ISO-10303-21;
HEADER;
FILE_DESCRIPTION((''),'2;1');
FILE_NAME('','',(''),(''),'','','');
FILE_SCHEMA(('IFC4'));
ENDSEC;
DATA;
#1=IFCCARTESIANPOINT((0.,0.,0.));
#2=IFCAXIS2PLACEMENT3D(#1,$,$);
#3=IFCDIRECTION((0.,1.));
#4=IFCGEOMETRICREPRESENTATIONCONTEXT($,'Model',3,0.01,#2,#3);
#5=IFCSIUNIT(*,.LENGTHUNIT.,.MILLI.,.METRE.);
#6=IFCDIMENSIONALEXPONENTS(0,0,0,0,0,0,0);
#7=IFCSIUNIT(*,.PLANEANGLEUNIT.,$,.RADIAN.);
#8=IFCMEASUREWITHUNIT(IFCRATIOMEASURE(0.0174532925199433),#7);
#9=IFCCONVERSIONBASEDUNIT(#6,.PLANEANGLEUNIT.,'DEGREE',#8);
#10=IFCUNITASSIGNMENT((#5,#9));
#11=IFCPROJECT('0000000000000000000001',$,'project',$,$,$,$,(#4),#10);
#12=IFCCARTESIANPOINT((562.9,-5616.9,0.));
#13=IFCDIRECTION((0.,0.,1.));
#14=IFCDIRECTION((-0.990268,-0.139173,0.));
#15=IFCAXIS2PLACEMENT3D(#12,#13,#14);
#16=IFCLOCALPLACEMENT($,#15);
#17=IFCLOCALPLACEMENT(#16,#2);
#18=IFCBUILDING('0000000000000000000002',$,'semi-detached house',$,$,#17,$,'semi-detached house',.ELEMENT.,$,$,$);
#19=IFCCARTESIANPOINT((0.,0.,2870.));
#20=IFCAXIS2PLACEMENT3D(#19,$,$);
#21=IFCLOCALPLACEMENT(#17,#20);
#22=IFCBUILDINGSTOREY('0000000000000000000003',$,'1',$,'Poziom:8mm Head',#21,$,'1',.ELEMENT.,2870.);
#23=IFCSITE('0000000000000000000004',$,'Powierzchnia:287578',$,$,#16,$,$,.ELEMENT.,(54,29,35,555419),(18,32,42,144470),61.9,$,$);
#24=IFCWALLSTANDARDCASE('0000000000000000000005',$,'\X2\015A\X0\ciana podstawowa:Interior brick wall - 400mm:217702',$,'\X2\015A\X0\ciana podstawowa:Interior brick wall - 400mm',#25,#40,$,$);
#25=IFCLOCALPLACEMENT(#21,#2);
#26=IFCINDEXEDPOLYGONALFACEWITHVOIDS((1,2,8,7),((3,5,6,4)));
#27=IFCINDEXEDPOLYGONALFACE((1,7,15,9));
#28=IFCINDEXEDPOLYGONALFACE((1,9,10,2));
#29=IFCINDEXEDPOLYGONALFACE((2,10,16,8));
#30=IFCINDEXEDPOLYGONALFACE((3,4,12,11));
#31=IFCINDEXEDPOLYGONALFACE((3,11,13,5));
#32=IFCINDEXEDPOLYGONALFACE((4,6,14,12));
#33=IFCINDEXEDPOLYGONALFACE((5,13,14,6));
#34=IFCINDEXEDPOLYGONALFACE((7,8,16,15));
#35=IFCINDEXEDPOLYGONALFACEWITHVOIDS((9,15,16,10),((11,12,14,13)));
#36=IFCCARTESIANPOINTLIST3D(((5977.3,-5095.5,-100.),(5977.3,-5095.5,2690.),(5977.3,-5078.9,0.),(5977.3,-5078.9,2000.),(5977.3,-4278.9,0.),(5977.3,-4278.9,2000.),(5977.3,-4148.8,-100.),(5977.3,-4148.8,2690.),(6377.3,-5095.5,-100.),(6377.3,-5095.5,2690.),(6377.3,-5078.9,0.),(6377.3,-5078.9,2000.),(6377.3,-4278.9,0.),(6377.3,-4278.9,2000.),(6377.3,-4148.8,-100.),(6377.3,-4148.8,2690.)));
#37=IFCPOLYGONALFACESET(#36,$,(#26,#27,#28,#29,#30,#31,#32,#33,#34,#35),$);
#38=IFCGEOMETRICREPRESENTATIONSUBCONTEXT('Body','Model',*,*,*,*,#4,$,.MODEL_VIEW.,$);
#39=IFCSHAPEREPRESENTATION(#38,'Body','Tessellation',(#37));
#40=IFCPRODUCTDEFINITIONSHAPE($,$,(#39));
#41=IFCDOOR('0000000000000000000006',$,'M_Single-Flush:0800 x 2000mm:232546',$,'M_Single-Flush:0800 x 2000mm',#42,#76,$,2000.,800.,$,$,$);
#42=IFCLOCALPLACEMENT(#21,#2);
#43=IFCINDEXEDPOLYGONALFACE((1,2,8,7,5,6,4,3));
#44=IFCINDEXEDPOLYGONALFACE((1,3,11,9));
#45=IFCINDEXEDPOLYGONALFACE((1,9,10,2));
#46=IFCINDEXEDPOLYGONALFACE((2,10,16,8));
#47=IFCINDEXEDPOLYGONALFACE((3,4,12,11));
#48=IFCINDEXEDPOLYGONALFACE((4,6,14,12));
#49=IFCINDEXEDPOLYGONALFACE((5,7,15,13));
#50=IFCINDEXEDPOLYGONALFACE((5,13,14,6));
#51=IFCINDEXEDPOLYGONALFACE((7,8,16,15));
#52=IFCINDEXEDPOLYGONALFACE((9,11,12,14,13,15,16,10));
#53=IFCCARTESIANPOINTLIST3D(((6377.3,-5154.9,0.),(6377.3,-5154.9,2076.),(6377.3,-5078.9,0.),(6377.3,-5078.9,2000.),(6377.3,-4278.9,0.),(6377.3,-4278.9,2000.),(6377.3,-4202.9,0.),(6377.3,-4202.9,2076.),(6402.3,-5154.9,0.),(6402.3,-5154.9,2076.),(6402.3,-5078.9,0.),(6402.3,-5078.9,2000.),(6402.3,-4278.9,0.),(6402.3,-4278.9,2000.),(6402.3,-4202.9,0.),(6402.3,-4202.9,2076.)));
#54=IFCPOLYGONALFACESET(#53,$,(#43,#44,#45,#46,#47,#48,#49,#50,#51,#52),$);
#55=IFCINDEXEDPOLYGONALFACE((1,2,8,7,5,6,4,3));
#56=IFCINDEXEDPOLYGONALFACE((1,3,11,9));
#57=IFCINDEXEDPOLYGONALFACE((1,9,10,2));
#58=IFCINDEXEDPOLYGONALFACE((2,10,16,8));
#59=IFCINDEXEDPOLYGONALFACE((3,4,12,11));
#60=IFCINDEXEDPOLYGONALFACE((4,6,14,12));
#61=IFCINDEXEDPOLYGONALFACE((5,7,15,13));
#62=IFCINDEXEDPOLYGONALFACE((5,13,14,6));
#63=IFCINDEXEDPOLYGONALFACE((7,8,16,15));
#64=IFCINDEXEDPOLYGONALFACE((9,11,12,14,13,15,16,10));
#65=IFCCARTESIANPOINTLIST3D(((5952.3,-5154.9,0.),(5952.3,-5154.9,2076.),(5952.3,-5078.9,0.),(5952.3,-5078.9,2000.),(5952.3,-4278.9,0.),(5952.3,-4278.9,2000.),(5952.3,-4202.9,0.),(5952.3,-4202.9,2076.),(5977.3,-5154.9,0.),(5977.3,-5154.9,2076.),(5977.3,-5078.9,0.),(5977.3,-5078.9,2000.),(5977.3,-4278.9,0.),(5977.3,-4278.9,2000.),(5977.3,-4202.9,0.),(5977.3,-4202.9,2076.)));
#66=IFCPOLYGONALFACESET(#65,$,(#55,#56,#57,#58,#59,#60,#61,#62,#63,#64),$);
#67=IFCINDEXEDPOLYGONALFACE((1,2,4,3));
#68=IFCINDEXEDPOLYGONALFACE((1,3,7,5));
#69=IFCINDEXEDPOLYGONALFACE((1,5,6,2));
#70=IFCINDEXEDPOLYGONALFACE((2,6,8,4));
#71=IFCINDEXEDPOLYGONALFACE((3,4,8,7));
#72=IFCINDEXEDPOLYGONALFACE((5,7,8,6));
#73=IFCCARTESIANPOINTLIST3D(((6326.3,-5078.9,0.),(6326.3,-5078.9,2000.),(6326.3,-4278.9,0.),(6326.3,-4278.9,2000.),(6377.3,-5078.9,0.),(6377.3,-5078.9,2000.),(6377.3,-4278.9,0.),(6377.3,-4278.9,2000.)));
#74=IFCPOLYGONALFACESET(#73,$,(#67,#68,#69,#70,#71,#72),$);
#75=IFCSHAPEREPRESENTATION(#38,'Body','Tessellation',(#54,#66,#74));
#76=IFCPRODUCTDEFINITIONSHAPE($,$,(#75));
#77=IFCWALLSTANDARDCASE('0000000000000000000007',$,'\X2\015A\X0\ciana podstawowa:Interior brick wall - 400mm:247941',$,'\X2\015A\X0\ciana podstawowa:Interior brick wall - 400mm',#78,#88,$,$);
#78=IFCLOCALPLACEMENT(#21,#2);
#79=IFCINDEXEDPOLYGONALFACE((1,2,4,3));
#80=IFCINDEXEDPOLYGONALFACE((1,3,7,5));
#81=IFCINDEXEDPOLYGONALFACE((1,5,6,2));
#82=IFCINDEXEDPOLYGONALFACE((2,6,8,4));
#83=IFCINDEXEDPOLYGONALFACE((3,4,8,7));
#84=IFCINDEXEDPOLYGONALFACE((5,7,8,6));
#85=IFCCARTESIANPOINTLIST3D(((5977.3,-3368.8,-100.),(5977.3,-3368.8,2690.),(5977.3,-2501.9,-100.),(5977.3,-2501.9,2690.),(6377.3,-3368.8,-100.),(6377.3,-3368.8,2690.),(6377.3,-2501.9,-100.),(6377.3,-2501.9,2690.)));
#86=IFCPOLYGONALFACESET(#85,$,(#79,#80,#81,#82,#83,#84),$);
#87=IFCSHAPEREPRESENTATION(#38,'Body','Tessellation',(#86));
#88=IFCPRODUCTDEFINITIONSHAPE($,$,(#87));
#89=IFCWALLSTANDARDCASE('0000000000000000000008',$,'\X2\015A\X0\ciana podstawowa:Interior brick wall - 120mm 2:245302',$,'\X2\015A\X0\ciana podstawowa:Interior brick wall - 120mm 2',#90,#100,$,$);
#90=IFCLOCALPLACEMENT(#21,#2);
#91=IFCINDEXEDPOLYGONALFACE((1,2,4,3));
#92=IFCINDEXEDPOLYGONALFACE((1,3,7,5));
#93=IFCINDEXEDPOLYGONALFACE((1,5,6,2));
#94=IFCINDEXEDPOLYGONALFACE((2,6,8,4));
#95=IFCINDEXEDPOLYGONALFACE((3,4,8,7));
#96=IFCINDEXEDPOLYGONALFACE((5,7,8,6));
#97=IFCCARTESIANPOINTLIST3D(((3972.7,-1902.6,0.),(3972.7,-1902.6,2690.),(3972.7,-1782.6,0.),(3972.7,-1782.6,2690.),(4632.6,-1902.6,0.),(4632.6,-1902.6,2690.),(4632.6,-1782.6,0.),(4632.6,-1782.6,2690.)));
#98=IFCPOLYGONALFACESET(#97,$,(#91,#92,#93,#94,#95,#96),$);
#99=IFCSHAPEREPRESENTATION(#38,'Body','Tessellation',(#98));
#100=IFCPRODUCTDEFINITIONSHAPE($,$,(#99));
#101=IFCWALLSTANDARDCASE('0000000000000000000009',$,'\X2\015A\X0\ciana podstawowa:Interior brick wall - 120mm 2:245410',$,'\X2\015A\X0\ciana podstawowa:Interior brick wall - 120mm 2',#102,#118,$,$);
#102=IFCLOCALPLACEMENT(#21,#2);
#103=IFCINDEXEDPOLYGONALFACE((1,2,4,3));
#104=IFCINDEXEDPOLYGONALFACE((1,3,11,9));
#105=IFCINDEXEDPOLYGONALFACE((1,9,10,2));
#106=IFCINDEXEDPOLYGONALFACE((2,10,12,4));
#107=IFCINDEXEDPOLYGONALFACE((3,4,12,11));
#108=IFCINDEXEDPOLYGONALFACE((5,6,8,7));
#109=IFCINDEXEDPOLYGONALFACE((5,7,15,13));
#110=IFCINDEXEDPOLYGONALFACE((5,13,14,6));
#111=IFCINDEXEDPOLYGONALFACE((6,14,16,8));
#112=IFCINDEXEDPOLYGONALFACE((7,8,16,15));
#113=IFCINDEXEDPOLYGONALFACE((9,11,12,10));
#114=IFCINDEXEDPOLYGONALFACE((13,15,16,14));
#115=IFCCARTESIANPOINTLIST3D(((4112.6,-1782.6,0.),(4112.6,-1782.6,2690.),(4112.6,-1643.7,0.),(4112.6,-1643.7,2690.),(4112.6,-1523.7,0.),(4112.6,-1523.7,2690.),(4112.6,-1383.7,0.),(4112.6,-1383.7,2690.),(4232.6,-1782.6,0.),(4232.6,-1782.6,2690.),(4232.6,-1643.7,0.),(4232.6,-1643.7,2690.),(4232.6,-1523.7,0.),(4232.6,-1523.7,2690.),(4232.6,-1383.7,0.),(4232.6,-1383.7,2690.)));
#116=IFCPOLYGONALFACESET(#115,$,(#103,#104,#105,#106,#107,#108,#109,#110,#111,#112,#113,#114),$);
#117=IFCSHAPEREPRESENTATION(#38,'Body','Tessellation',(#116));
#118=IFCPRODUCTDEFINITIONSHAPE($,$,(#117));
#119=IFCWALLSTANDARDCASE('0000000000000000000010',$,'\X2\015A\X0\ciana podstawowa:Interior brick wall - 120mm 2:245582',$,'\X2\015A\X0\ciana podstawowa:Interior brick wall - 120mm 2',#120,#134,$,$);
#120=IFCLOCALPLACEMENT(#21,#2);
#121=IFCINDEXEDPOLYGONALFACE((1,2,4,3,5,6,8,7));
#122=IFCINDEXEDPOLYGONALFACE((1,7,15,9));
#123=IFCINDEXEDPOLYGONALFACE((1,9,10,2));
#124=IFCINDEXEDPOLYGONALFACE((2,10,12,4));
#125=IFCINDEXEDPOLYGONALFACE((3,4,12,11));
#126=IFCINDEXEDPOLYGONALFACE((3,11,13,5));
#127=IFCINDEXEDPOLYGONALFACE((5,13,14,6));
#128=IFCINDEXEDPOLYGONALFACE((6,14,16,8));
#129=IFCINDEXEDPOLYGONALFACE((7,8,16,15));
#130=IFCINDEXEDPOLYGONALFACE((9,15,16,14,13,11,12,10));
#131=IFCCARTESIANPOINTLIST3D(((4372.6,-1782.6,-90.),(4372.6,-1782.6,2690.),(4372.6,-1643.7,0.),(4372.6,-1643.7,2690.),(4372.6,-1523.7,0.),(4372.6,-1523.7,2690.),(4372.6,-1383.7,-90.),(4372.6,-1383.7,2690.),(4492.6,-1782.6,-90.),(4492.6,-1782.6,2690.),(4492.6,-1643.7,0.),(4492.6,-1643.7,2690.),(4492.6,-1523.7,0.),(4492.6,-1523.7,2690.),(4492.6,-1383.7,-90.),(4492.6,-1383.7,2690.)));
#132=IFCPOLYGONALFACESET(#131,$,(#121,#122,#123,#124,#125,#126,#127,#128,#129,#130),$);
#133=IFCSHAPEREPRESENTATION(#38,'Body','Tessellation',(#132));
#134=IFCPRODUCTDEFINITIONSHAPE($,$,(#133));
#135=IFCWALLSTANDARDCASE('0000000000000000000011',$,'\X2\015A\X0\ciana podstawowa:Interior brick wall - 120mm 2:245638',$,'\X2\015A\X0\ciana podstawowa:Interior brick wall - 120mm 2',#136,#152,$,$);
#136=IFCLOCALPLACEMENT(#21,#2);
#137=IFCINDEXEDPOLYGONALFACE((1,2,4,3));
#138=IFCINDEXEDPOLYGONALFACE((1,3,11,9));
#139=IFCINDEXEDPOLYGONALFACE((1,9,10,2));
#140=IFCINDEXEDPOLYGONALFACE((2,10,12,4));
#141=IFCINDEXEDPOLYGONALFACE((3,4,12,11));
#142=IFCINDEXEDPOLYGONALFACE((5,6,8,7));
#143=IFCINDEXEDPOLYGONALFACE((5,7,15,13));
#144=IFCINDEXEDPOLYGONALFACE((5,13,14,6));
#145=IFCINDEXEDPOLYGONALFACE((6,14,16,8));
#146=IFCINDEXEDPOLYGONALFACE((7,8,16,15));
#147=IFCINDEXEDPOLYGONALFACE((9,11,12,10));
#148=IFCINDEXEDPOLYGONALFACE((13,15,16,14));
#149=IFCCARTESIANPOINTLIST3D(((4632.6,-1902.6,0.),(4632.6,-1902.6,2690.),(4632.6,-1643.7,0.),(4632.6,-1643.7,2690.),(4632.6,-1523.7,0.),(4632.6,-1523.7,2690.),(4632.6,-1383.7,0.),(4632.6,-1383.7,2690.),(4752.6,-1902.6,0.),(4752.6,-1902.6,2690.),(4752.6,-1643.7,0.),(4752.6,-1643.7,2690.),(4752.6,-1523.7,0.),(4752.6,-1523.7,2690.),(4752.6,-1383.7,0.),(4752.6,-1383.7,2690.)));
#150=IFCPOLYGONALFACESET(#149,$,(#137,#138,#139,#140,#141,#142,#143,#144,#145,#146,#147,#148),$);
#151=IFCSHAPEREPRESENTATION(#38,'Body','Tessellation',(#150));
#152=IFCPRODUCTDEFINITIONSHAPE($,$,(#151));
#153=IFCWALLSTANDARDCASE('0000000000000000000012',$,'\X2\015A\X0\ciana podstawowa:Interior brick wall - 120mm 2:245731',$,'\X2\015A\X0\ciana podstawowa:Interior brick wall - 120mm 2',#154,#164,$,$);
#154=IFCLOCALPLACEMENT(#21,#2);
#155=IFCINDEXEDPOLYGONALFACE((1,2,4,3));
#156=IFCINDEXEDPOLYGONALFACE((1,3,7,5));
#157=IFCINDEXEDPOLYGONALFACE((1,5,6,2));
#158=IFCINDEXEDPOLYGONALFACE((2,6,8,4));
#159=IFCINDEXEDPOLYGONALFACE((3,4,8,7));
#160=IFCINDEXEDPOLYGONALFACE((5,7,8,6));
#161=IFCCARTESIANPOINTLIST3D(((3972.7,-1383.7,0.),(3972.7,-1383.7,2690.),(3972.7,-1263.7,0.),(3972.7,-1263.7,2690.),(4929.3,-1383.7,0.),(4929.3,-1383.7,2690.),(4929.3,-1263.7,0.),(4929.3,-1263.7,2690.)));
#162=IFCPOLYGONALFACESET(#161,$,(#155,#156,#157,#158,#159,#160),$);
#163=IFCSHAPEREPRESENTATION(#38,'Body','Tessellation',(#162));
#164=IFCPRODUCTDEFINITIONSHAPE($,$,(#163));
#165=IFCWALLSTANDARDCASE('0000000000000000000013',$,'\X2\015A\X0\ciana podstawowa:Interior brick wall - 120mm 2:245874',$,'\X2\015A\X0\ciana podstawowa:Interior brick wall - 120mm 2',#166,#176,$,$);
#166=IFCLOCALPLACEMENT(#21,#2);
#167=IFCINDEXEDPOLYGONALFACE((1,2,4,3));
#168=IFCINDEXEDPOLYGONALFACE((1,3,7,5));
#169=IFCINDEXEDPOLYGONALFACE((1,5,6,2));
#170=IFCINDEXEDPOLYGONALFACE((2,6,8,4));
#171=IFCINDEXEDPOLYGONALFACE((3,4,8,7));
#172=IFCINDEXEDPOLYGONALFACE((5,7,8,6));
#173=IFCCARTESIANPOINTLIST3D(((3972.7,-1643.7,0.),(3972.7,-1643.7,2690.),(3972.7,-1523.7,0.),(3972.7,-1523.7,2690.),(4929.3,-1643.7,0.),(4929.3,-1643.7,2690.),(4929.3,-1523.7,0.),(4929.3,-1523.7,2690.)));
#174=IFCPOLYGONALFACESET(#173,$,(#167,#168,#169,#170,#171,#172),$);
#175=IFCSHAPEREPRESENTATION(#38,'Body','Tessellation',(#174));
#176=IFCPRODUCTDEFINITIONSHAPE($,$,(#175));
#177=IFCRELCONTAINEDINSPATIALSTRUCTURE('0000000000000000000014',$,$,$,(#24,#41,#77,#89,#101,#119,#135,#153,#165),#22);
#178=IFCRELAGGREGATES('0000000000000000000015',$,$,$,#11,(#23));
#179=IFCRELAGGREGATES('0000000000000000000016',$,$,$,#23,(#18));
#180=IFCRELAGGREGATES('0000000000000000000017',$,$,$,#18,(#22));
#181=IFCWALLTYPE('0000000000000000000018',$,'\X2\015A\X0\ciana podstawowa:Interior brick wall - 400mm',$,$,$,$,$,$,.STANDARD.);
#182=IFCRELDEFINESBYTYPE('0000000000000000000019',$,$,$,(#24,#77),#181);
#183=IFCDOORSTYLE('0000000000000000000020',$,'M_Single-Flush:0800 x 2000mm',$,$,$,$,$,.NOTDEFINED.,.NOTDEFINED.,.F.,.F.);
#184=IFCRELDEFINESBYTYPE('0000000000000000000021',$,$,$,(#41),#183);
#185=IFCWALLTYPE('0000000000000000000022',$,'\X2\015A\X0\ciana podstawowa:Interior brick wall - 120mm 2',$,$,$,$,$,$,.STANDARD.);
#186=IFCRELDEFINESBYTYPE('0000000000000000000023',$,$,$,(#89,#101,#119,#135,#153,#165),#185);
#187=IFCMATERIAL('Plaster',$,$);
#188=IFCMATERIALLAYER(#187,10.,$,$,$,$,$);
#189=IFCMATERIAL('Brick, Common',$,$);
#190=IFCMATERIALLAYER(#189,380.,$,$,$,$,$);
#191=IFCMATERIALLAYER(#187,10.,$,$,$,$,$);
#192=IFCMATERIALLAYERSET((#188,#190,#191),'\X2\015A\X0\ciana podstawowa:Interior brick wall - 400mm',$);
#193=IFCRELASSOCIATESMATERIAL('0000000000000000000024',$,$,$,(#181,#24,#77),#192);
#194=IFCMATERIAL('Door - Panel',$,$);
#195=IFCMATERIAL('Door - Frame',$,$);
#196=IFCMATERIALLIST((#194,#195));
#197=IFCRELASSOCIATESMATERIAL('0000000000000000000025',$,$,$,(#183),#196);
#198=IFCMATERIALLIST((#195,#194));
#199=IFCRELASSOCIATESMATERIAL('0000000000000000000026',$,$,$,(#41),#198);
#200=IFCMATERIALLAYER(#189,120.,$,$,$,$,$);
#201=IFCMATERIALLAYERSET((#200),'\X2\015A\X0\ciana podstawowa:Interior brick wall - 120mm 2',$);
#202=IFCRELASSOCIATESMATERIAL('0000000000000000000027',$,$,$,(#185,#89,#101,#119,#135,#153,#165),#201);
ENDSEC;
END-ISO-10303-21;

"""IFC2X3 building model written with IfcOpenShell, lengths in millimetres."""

from ifc_helpers import new_model, entity, si_unit, converted_unit, direction, frame, frame_2d, origin, place, context, subcontext, project, spatial, polyline, rectangle, outline, extrude, clip, bounded_halfspace, source, transform, mapped, material, material_list, layer, layer_set, layer_usage, type_object, type_shapes, element, fill, save


model = new_model("IFC2X3")

# Units and contexts
model_context = context("Model", 3, precision=0.01, world=origin(), true_north=direction((0.0, 1.0)))
body_context = subcontext(model_context, "Body", "Model", "MODEL_VIEW")
ifc_project = project(units=[si_unit("LENGTHUNIT", "METRE", prefix="MILLI"), converted_unit("PLANEANGLEUNIT", "DEGREE", entity("IfcRatioMeasure", 0.0174532925199433), si_unit("PLANEANGLEUNIT", "RADIAN"), dimensions=[0, 0, 0, 0, 0, 0, 0])], contexts=[model_context])

# Site, building, storey
site_placement = place(None, frame((562.9, -5616.9, 0.0), z_axis=(0.0, 0.0, 1.0), x_axis=(-0.990268, -0.139173, 0.0)))
site = spatial("IfcSite", under=ifc_project, at=site_placement, Name="Powierzchnia:287578", CompositionType="ELEMENT", RefLatitude=(54, 29, 35, 555419), RefLongitude=(18, 32, 42, 144470), RefElevation=61.9)
building_placement = place(site_placement, origin())
building = spatial("IfcBuilding", under=site, at=building_placement, Name="semi-detached house", LongName="semi-detached house", CompositionType="ELEMENT")
storey_placement = place(building_placement, frame((0.0, 0.0, 2870.0)))
storey = spatial("IfcBuildingStorey", under=building, at=storey_placement, Name="1", ObjectType="Poziom:8mm Head", LongName="1", CompositionType="ELEMENT", Elevation=2870.0)

# Shared definitions
ifc_material_1 = material(Name="Brick, Common")
ifc_material_2 = material(Name="Plaster")

# Shared definitions
ifc_material_3 = material(Name="Door - Frame")
ifc_material_4 = material(Name="Door - Panel")

# Wall, opening, door
ifc_layer_1 = layer(ifc_material_2, 10.0)
ifc_layer_2 = layer(ifc_material_1, 380.0)
ifc_layer_3 = layer(ifc_material_2, 10.0)
ifc_layer_set_1 = layer_set([ifc_layer_1, ifc_layer_2, ifc_layer_3], Name="Ściana podstawowa:Interior brick wall - 400mm")
ifc_layer_usage_1 = layer_usage(ifc_layer_set_1, "AXIS2", "NEGATIVE", 200.0)
wall_type_1 = type_object("IfcWallType", Name="Ściana podstawowa:Interior brick wall - 400mm", PredefinedType="STANDARD", material=ifc_layer_set_1)
wall_1_placement = place(storey_placement, frame((6177.3, -5095.5, -100.0), z_axis=(0.0, 0.0, 1.0), x_axis=(0.0, 1.0, 0.0)))
wall_1 = element("IfcWallStandardCase", 1, at=wall_1_placement, inside=storey, type_object=wall_type_1, material=ifc_layer_usage_1, Name="Ściana podstawowa:Interior brick wall - 400mm:217702", ObjectType="Ściana podstawowa:Interior brick wall - 400mm", context=body_context, shape_type="SweptSolid", body=[
    extrude(rectangle(XDim=946.7, YDim=400.0, at=frame_2d((473.4, 0.0), x_axis=(-1.0, 0.0))), origin(), (0.0, 0.0, 1.0), 2790.0),
])
opening_1_placement = place(wall_1_placement, frame((816.6, 200.0, 100.0)))
opening_1 = element("IfcOpeningElement", 2, at=opening_1_placement, cuts=wall_1, ObjectType="Opening", context=body_context, shape_type="SweptSolid", body=[
    extrude(rectangle(XDim=800.0, YDim=2000.0, at=frame_2d((1000.0, 400.0), x_axis=(0.0, 1.0))), frame((0.0, 0.0, 0.0), z_axis=(0.0, -1.0, 0.0), x_axis=(0.0, 0.0, 1.0)), (0.0, 0.0, 1.0), 400.0),
])
ifc_material_list_1 = material_list([ifc_material_3, ifc_material_4])
ifc_material_list_2 = material_list([ifc_material_4, ifc_material_3])
door_style_1 = type_object("IfcDoorStyle", Name="M_Single-Flush:0800 x 2000mm", ConstructionType="NOTDEFINED", OperationType="NOTDEFINED", ParameterTakesPrecedence=False, Sizeable=False, material=ifc_material_list_2)
shared_shape_1 = source(origin(), body_context, "Body", "SweptSolid", [
    extrude(outline(polyline([(-476.0, -1057.0), (476.0, -1057.0), (476.0, 1019.0), (400.0, 1019.0), (400.0, -981.0), (-400.0, -981.0), (-400.0, 1019.0), (-476.0, 1019.0), (-476.0, -1057.0)])), frame((400.0, 400.0, 1019.0), z_axis=(0.0, 1.0, 0.0), x_axis=(1.0, 0.0, 0.0)), (0.0, 0.0, 1.0), 25.0),
    extrude(outline(polyline([(-1057.0, -476.0), (1019.0, -476.0), (1019.0, -400.0), (-981.0, -400.0), (-981.0, 400.0), (1019.0, 400.0), (1019.0, 476.0), (-1057.0, 476.0), (-1057.0, -476.0)])), frame((400.0, -25.0, 1019.0), z_axis=(0.0, 1.0, 0.0), x_axis=(0.0, 0.0, -1.0)), (0.0, 0.0, 1.0), 25.0),
    extrude(rectangle(XDim=51.0, YDim=800.0, at=frame_2d((0.0, 0.0), x_axis=(1.0, 0.0))), frame((400.0, 374.5, 0.0), z_axis=(0.0, 0.0, 1.0), x_axis=(0.0, 1.0, 0.0)), (0.0, 0.0, 1.0), 2000.0),
])
type_shapes(door_style_1, [shared_shape_1])
door_1_placement = place(opening_1_placement, frame((0.0, 0.0, 0.0), z_axis=(0.0, 0.0, 1.0), x_axis=(-1.0, 0.0, 0.0)))
door_1 = element("IfcDoor", 3, at=door_1_placement, inside=storey, type_object=door_style_1, material=ifc_material_list_1, Name="M_Single-Flush:0800 x 2000mm:232546", ObjectType="M_Single-Flush:0800 x 2000mm", OverallHeight=2000.0, OverallWidth=800.0, context=body_context, shape_type="MappedRepresentation", body=[
    mapped(shared_shape_1, transform((0.0, 0.0, 0.0), scale=1.0)),
])
fill(opening_1, door_1)

# Walls
ifc_layer_usage_2 = layer_usage(ifc_layer_set_1, "AXIS2", "NEGATIVE", 200.0)
wall_2_placement = place(storey_placement, frame((6177.3, -3368.8, -100.0), z_axis=(0.0, 0.0, 1.0), x_axis=(0.0, 1.0, 0.0)))
element("IfcWallStandardCase", 4, at=wall_2_placement, inside=storey, type_object=wall_type_1, material=ifc_layer_usage_2, Name="Ściana podstawowa:Interior brick wall - 400mm:247941", ObjectType="Ściana podstawowa:Interior brick wall - 400mm", context=body_context, shape_type="SweptSolid", body=[
    extrude(rectangle(XDim=866.9, YDim=400.0, at=frame_2d((433.5, 0.0), x_axis=(-1.0, 0.0))), origin(), (0.0, 0.0, 1.0), 2790.0),
])
ifc_layer_4 = layer(ifc_material_1, 120.0)
ifc_layer_set_2 = layer_set([ifc_layer_4], Name="Ściana podstawowa:Interior brick wall - 120mm 2")
ifc_layer_usage_3 = layer_usage(ifc_layer_set_2, "AXIS2", "NEGATIVE", 60.0)
wall_type_2 = type_object("IfcWallType", Name="Ściana podstawowa:Interior brick wall - 120mm 2", PredefinedType="STANDARD", material=ifc_layer_set_2)
wall_3_placement = place(storey_placement, frame((3972.7, -1842.6, 0.0)))
element("IfcWallStandardCase", 5, at=wall_3_placement, inside=storey, type_object=wall_type_2, material=ifc_layer_usage_3, Name="Ściana podstawowa:Interior brick wall - 120mm 2:245302", ObjectType="Ściana podstawowa:Interior brick wall - 120mm 2", context=body_context, shape_type="SweptSolid", body=[
    extrude(rectangle(XDim=659.9, YDim=120.0, at=frame_2d((329.9, 0.0), x_axis=(-1.0, 0.0))), origin(), (0.0, 0.0, 1.0), 2690.0),
])

# Wall, opening
ifc_layer_usage_4 = layer_usage(ifc_layer_set_2, "AXIS2", "NEGATIVE", 60.0)
wall_4_placement = place(storey_placement, frame((4172.6, -1782.6, 0.0), z_axis=(0.0, 0.0, 1.0), x_axis=(0.0, 1.0, 0.0)))
wall_4 = element("IfcWallStandardCase", 6, at=wall_4_placement, inside=storey, type_object=wall_type_2, material=ifc_layer_usage_4, Name="Ściana podstawowa:Interior brick wall - 120mm 2:245410", ObjectType="Ściana podstawowa:Interior brick wall - 120mm 2", context=body_context, shape_type="SweptSolid", body=[
    extrude(rectangle(XDim=398.9, YDim=120.0, at=frame_2d((199.5, 0.0), x_axis=(-1.0, 0.0))), origin(), (0.0, 0.0, 1.0), 2690.0),
])
opening_2_placement = place(storey_placement, frame((4172.6, -1782.6, 0.0), z_axis=(0.0, 0.0, 1.0), x_axis=(0.0, 1.0, 0.0)))
element("IfcOpeningElement", 7, at=opening_2_placement, cuts=wall_4, ObjectType="Opening", context=body_context, shape_type="SweptSolid", body=[
    extrude(rectangle(XDim=2690.0, YDim=120.0, at=frame_2d((0.0, 0.0), x_axis=(1.0, 0.0))), frame((138.9, 0.0, 1345.0), z_axis=(1.0, 0.0, 0.0), x_axis=(0.0, 0.0, -1.0)), (0.0, 0.0, 1.0), 120.0),
])

# Wall
ifc_layer_usage_5 = layer_usage(ifc_layer_set_2, "AXIS2", "NEGATIVE", 60.0)
wall_5_placement = place(storey_placement, frame((4432.6, -1782.6, -90.0), z_axis=(0.0, 0.0, 1.0), x_axis=(0.0, 1.0, 0.0)))
element("IfcWallStandardCase", 8, at=wall_5_placement, inside=storey, type_object=wall_type_2, material=ifc_layer_usage_5, Name="Ściana podstawowa:Interior brick wall - 120mm 2:245582", ObjectType="Ściana podstawowa:Interior brick wall - 120mm 2", context=body_context, shape_type="Clipping", body=[
    clip(extrude(rectangle(XDim=398.9, YDim=120.0, at=frame_2d((199.5, 0.0), x_axis=(-1.0, 0.0))), origin(), (0.0, 0.0, 1.0), 2780.0), bounded_halfspace(frame((138.9, 60.0, 90.0), z_axis=(0.0, 0.0, -1.0), x_axis=(1.0, 0.0, 0.0)), True, frame((138.9, 60.0, 90.0), z_axis=(0.0, 0.0, -1.0), x_axis=(1.0, 0.0, 0.0)), polyline([(0.0, 0.0), (120.0, 0.0), (120.0, 120.0), (0.0, 120.0), (0.0, 0.0)]))),
])

# Wall, opening
ifc_layer_usage_6 = layer_usage(ifc_layer_set_2, "AXIS2", "NEGATIVE", 60.0)
wall_6_placement = place(storey_placement, frame((4692.6, -1902.6, 0.0), z_axis=(0.0, 0.0, 1.0), x_axis=(0.0, 1.0, 0.0)))
wall_6 = element("IfcWallStandardCase", 9, at=wall_6_placement, inside=storey, type_object=wall_type_2, material=ifc_layer_usage_6, Name="Ściana podstawowa:Interior brick wall - 120mm 2:245638", ObjectType="Ściana podstawowa:Interior brick wall - 120mm 2", context=body_context, shape_type="SweptSolid", body=[
    extrude(rectangle(XDim=518.9, YDim=120.0, at=frame_2d((259.5, 0.0), x_axis=(-1.0, 0.0))), origin(), (0.0, 0.0, 1.0), 2690.0),
])
opening_3_placement = place(storey_placement, frame((4692.6, -1902.6, 0.0), z_axis=(0.0, 0.0, 1.0), x_axis=(0.0, 1.0, 0.0)))
element("IfcOpeningElement", 10, at=opening_3_placement, cuts=wall_6, ObjectType="Opening", context=body_context, shape_type="SweptSolid", body=[
    extrude(rectangle(XDim=2690.0, YDim=120.0, at=frame_2d((0.0, 0.0), x_axis=(1.0, 0.0))), frame((258.9, 0.0, 1345.0), z_axis=(1.0, 0.0, 0.0), x_axis=(0.0, 0.0, -1.0)), (0.0, 0.0, 1.0), 120.0),
])

# Walls
ifc_layer_usage_7 = layer_usage(ifc_layer_set_2, "AXIS2", "POSITIVE", -60.0)
wall_7_placement = place(storey_placement, frame((3972.7, -1323.7, 0.0)))
element("IfcWallStandardCase", 11, at=wall_7_placement, inside=storey, type_object=wall_type_2, material=ifc_layer_usage_7, Name="Ściana podstawowa:Interior brick wall - 120mm 2:245731", ObjectType="Ściana podstawowa:Interior brick wall - 120mm 2", context=body_context, shape_type="SweptSolid", body=[
    extrude(rectangle(XDim=956.6, YDim=120.0, at=frame_2d((478.3, 0.0), x_axis=(-1.0, 0.0))), origin(), (0.0, 0.0, 1.0), 2690.0),
])
ifc_layer_usage_8 = layer_usage(ifc_layer_set_2, "AXIS2", "NEGATIVE", 60.0)
wall_8_placement = place(storey_placement, frame((3972.7, -1583.7, 0.0)))
element("IfcWallStandardCase", 12, at=wall_8_placement, inside=storey, type_object=wall_type_2, material=ifc_layer_usage_8, Name="Ściana podstawowa:Interior brick wall - 120mm 2:245874", ObjectType="Ściana podstawowa:Interior brick wall - 120mm 2", context=body_context, shape_type="SweptSolid", body=[
    extrude(rectangle(XDim=956.6, YDim=120.0, at=frame_2d((478.3, 0.0), x_axis=(-1.0, 0.0))), origin(), (0.0, 0.0, 1.0), 2690.0),
])

save(model, "model.ifc")
